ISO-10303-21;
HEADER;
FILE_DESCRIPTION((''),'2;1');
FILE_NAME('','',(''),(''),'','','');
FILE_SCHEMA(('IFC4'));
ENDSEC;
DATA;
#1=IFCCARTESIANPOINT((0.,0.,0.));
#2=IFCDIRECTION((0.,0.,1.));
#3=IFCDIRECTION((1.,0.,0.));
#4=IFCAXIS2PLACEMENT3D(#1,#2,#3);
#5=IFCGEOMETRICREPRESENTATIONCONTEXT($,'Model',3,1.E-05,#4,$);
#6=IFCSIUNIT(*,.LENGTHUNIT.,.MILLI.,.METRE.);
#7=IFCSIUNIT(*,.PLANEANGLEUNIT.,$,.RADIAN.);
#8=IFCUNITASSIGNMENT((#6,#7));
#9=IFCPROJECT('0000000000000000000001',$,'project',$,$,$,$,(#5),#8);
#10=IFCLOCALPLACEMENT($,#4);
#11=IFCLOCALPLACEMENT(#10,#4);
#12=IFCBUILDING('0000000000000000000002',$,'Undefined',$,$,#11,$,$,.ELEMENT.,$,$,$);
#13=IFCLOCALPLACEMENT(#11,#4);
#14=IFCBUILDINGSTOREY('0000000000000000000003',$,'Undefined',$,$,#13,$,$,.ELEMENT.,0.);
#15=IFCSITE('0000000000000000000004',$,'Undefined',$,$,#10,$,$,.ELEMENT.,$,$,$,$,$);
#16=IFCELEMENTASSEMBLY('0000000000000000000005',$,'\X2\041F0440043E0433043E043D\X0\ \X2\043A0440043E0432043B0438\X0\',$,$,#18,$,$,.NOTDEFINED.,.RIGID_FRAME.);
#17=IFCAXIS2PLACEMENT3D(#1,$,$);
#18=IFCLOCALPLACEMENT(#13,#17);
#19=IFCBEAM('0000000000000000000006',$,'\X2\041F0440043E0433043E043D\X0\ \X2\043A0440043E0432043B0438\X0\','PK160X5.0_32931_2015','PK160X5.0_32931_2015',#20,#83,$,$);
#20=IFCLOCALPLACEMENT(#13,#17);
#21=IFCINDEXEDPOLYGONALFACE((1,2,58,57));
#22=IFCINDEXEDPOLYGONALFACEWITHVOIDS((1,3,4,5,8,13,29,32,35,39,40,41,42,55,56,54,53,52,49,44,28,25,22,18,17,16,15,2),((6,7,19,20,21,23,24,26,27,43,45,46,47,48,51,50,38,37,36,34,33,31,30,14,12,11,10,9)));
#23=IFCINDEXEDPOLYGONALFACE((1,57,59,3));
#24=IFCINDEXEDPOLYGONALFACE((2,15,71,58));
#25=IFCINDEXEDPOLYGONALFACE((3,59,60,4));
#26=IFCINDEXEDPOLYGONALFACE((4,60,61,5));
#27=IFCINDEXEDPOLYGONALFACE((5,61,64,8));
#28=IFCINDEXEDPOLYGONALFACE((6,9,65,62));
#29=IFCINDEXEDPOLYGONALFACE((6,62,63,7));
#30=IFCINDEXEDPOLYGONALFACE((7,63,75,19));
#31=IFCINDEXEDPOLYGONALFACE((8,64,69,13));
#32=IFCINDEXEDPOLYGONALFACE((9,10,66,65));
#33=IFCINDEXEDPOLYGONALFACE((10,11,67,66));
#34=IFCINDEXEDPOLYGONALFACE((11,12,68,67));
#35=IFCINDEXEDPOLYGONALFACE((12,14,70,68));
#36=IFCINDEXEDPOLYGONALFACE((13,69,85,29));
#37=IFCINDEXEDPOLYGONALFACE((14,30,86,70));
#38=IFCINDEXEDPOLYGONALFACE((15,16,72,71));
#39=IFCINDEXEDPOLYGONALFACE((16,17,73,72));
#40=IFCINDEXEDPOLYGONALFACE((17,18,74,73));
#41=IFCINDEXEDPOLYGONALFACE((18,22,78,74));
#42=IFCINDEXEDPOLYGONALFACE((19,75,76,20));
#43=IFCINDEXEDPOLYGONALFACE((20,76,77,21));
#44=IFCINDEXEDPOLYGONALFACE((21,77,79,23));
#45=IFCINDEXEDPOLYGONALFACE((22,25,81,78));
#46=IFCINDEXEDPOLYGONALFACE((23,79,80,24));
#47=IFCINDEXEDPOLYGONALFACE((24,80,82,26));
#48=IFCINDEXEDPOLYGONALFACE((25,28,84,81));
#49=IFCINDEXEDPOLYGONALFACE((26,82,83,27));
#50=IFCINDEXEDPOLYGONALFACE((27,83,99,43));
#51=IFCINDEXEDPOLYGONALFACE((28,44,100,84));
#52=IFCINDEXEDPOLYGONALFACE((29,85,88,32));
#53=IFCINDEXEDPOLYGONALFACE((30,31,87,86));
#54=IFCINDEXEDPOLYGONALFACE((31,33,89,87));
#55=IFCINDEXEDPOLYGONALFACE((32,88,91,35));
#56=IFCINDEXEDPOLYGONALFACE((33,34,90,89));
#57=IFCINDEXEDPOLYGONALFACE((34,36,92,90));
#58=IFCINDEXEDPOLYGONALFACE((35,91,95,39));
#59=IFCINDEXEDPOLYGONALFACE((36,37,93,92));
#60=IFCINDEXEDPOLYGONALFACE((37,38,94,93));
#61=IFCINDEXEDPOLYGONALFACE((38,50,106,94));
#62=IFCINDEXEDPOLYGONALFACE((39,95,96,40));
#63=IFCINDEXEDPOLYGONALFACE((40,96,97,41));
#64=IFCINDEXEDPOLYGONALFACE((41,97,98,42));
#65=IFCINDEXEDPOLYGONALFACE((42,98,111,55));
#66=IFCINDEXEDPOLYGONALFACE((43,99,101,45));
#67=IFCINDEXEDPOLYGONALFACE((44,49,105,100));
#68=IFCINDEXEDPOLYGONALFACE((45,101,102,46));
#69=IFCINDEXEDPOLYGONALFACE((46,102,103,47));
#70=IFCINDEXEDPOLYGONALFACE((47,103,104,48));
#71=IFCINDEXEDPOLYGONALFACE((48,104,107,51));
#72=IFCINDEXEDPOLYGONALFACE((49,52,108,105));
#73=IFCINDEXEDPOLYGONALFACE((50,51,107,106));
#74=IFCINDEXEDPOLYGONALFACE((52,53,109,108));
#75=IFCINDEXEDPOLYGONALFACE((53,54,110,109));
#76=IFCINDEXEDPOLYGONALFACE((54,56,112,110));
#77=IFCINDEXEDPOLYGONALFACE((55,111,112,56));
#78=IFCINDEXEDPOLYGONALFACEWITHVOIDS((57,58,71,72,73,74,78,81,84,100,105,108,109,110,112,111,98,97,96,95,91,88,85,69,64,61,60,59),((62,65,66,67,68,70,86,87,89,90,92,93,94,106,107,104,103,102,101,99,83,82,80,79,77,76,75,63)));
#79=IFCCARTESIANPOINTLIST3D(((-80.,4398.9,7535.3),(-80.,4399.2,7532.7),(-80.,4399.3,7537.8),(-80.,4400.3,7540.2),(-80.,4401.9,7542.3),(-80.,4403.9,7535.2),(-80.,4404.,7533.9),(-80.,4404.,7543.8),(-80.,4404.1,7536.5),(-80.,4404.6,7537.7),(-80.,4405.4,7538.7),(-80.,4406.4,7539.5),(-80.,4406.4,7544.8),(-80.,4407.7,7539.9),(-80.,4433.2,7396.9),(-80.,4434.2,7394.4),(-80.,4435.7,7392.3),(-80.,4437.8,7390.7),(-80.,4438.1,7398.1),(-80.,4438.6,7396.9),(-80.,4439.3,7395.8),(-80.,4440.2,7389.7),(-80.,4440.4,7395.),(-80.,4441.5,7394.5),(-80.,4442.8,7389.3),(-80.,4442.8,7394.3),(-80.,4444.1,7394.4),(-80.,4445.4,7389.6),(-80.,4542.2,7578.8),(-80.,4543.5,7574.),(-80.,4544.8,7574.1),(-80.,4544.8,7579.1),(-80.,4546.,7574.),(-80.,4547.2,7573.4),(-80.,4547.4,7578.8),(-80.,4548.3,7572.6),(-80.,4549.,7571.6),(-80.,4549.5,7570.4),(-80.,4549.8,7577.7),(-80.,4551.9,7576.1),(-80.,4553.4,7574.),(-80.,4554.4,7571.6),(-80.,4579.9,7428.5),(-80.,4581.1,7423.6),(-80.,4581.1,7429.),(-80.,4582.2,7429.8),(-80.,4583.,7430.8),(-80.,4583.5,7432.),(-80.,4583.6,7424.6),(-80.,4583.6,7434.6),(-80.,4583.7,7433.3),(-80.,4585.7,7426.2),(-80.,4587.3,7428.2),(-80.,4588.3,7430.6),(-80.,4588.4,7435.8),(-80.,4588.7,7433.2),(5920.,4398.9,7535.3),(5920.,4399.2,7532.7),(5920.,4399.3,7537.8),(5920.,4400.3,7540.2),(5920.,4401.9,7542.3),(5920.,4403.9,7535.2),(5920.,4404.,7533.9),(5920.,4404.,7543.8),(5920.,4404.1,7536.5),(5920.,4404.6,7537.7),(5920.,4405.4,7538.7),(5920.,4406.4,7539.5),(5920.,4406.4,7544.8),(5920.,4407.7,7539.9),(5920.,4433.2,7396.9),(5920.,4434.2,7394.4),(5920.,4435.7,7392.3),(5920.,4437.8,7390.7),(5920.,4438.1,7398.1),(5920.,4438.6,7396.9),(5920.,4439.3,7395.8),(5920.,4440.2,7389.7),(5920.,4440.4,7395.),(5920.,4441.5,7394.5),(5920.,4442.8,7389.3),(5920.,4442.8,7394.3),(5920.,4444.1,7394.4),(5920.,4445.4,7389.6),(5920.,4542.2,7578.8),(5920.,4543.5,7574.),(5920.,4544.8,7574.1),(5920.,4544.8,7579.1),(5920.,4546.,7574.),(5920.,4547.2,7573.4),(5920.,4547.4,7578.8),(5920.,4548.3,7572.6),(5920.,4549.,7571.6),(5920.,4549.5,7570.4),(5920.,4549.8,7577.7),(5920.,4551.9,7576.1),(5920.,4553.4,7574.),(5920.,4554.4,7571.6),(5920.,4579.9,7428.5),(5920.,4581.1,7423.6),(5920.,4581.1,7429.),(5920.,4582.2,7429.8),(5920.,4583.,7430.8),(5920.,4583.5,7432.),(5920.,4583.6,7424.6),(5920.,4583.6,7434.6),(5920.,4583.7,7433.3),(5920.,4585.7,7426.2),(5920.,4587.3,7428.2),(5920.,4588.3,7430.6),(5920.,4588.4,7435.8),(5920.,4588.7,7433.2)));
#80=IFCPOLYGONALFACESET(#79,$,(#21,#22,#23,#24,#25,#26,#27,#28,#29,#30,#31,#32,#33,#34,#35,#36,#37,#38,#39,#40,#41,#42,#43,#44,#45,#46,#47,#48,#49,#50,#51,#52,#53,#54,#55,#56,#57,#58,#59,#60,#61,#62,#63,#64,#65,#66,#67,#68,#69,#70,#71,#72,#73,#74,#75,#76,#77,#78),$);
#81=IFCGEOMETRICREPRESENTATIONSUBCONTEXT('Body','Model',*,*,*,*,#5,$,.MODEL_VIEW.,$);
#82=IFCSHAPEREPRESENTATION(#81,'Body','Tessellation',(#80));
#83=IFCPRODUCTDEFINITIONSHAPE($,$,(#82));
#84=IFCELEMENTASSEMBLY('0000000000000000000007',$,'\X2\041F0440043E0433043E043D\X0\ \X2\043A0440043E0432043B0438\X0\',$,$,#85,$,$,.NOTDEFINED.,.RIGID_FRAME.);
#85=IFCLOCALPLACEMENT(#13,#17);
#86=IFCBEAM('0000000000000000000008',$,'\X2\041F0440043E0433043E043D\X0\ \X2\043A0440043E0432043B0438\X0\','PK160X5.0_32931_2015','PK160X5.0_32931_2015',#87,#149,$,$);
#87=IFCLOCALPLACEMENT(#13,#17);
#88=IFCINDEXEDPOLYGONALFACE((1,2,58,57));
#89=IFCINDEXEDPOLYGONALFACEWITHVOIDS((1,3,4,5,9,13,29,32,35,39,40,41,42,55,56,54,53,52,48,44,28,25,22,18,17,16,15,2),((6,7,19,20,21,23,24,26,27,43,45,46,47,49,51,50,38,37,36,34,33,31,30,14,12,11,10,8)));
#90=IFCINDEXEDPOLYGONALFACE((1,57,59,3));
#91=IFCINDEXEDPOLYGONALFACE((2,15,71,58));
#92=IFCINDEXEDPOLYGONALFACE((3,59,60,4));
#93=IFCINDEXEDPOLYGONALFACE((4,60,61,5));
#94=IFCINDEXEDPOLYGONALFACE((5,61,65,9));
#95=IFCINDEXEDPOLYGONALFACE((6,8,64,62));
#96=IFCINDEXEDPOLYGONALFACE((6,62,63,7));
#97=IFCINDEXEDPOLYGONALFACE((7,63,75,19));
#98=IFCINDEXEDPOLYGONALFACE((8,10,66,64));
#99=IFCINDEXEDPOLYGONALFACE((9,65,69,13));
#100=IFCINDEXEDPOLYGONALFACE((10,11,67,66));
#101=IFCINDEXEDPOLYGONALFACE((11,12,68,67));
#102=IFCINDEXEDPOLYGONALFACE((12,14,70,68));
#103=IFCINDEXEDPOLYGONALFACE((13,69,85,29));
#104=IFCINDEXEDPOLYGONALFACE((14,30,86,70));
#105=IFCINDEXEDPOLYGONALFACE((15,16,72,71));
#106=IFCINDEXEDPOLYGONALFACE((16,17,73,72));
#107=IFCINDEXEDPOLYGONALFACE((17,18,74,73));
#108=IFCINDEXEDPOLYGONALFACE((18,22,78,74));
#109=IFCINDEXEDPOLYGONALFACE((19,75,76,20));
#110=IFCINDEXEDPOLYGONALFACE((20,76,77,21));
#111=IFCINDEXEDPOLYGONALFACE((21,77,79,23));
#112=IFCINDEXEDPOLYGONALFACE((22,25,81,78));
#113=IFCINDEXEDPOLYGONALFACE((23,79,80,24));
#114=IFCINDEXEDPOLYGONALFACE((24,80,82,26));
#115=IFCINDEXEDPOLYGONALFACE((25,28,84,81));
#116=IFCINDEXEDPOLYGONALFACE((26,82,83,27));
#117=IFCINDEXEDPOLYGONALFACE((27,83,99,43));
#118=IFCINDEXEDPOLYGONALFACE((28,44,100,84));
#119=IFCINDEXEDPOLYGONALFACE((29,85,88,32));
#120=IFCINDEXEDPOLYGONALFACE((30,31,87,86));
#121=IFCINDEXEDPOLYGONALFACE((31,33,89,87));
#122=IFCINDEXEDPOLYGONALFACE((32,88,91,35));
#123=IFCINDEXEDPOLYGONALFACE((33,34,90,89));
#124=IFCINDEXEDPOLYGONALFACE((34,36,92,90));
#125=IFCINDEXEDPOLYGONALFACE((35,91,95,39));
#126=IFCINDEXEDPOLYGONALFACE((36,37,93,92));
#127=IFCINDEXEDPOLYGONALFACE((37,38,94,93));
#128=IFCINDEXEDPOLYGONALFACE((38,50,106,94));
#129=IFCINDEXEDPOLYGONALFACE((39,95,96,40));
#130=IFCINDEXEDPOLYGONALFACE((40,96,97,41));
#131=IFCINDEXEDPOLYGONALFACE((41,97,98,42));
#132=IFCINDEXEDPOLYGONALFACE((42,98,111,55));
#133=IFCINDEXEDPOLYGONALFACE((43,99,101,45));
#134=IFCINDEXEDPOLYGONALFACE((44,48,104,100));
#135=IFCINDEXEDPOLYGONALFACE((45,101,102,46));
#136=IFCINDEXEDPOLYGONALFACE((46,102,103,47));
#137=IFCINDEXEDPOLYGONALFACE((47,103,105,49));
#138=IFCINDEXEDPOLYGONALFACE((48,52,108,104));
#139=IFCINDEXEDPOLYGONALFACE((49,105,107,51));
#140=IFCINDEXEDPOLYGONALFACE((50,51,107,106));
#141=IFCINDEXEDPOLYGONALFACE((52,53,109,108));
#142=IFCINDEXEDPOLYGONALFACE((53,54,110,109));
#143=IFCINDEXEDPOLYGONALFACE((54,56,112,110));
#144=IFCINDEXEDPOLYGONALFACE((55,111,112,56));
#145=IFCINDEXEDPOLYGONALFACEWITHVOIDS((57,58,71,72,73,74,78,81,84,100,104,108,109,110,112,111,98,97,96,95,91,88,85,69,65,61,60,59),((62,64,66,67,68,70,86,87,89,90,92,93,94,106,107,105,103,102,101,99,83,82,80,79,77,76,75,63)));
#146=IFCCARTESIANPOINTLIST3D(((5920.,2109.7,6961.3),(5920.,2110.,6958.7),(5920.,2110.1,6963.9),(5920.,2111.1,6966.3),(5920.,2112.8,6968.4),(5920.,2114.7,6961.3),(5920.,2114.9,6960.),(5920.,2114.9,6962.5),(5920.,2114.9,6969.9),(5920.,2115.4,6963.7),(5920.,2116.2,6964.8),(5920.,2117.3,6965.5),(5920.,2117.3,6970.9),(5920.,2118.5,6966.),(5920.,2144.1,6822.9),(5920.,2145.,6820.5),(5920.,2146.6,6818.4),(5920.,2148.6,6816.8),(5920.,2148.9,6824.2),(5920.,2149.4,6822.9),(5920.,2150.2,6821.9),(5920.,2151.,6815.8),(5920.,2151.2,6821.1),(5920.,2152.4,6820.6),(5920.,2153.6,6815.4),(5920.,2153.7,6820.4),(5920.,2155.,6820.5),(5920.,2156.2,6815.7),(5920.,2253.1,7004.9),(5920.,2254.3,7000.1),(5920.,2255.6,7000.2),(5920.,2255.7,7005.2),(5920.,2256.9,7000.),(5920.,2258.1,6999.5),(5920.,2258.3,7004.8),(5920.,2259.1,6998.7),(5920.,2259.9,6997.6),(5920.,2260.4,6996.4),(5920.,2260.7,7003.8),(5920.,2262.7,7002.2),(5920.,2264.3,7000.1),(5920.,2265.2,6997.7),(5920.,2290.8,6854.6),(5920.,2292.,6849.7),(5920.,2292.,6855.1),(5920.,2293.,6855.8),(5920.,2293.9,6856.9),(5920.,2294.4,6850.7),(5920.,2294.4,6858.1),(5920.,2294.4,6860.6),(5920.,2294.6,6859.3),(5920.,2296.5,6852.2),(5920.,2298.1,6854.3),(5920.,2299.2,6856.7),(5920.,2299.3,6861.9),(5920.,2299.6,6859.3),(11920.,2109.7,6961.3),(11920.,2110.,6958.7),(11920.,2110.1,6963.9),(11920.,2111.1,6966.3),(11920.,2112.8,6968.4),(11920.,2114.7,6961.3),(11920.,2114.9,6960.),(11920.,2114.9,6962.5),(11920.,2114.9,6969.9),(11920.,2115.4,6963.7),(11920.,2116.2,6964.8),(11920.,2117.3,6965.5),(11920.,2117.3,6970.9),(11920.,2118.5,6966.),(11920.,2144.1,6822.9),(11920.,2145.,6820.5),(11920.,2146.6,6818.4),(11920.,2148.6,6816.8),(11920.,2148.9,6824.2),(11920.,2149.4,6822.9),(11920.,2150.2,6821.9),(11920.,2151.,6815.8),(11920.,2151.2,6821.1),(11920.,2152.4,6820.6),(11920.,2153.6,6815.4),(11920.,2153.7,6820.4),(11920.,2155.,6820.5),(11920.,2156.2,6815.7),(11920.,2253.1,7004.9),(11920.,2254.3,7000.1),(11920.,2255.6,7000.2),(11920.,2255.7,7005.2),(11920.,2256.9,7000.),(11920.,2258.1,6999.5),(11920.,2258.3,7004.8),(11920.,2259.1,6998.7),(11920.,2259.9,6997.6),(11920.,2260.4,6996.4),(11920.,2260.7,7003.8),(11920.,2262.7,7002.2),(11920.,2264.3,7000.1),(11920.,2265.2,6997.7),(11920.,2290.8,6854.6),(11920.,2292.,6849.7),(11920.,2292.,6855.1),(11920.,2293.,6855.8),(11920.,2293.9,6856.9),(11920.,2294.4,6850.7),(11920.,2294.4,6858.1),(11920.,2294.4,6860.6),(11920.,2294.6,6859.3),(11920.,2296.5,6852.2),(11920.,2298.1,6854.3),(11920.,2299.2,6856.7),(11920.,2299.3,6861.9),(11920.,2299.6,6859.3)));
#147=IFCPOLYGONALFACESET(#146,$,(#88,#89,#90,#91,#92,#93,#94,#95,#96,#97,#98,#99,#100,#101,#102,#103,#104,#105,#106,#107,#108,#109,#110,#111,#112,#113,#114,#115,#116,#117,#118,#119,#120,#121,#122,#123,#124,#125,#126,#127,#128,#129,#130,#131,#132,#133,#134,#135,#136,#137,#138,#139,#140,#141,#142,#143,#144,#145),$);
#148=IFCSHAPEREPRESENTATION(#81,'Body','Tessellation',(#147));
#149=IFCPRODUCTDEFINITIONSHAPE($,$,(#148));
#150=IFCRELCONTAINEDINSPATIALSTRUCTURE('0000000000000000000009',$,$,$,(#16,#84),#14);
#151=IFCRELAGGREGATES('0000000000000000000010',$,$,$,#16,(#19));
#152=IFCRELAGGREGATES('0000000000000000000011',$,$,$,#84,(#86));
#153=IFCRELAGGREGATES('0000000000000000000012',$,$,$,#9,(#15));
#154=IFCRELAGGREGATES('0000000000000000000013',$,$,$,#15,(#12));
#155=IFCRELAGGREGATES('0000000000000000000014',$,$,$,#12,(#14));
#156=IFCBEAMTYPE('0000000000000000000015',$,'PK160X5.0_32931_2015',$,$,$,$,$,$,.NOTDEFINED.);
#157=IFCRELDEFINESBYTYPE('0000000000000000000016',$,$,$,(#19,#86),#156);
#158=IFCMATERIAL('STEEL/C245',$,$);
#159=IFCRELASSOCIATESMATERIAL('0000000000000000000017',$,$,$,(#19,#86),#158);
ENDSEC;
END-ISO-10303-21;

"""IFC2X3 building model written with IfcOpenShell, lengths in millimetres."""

from ifc_helpers import new_model, si_unit, frame, origin_with_axes, origin_2d_with_axis, place, context, subcontext, project, spatial, hollow_rectangle, extrude, material, type_object, element, aggregate, save


model = new_model("IFC2X3")

# Units and contexts
model_context = context("Model", 3, precision=1e-05, world=origin_with_axes())
body_context = subcontext(model_context, "Body", "Model", "MODEL_VIEW")
ifc_project = project(units=[si_unit("LENGTHUNIT", "METRE", prefix="MILLI"), si_unit("PLANEANGLEUNIT", "RADIAN")], contexts=[model_context])

# Site, building, storey
site_placement = place(None, origin_with_axes())
site = spatial("IfcSite", under=ifc_project, at=site_placement, Name="Undefined", CompositionType="ELEMENT")
building_placement = place(site_placement, origin_with_axes())
building = spatial("IfcBuilding", under=site, at=building_placement, Name="Undefined", CompositionType="ELEMENT")
storey_placement = place(building_placement, origin_with_axes())
storey = spatial("IfcBuildingStorey", under=building, at=storey_placement, Name="Undefined", CompositionType="ELEMENT", Elevation=0.0)

# Shared definitions
ifc_material = material(Name="STEEL/C245")

# Element assemblies, beams
beam_type_1 = type_object("IfcBeamType", Name="PK160X5.0_32931_2015", PredefinedType="NOTDEFINED")
assembly_1_placement = place(storey_placement, origin_with_axes())
assembly_1 = element("IfcElementAssembly", 1, at=assembly_1_placement, inside=storey, Name="Прогон кровли", AssemblyPlace="NOTDEFINED", PredefinedType="RIGID_FRAME")
beam_1_placement = place(assembly_1_placement, frame((-80.0, 4493.8, 7484.2), z_axis=(0.0, -0.243188, 0.969979), x_axis=(1.0, 0.0, 0.0)))
beam_1 = element("IfcBeam", 2, at=beam_1_placement, type_object=beam_type_1, material=ifc_material, Name="Прогон кровли", Description="PK160X5.0_32931_2015", ObjectType="PK160X5.0_32931_2015", context=body_context, shape_type="SweptSolid", body=[
    extrude(hollow_rectangle(XDim=160.0, YDim=160.0, WallThickness=5.0, InnerFilletRadius=5.0, OuterFilletRadius=10.0, at=origin_2d_with_axis()), frame((6000.0, 0.0, 0.0), z_axis=(-1.0, 0.0, 0.0), x_axis=(0.0, -1.0, 0.0)), (0.0, 0.0, 1.0), 6000.0),
])
aggregate(assembly_1, [beam_1])
assembly_2_placement = place(storey_placement, origin_with_axes())
assembly_2 = element("IfcElementAssembly", 3, at=assembly_2_placement, inside=storey, Name="Прогон кровли", AssemblyPlace="NOTDEFINED", PredefinedType="RIGID_FRAME")
beam_2_placement = place(assembly_2_placement, frame((5920.0, 2204.6, 6910.3), z_axis=(0.0, -0.243188, 0.969979), x_axis=(1.0, 0.0, 0.0)))
beam_2 = element("IfcBeam", 4, at=beam_2_placement, type_object=beam_type_1, material=ifc_material, Name="Прогон кровли", Description="PK160X5.0_32931_2015", ObjectType="PK160X5.0_32931_2015", context=body_context, shape_type="SweptSolid", body=[
    extrude(hollow_rectangle(XDim=160.0, YDim=160.0, WallThickness=5.0, InnerFilletRadius=5.0, OuterFilletRadius=10.0, at=origin_2d_with_axis()), frame((6000.0, 0.0, 0.0), z_axis=(-1.0, 0.0, 0.0), x_axis=(0.0, -1.0, 0.0)), (0.0, 0.0, 1.0), 6000.0),
])
aggregate(assembly_2, [beam_2])

save(model, "model.ifc")
